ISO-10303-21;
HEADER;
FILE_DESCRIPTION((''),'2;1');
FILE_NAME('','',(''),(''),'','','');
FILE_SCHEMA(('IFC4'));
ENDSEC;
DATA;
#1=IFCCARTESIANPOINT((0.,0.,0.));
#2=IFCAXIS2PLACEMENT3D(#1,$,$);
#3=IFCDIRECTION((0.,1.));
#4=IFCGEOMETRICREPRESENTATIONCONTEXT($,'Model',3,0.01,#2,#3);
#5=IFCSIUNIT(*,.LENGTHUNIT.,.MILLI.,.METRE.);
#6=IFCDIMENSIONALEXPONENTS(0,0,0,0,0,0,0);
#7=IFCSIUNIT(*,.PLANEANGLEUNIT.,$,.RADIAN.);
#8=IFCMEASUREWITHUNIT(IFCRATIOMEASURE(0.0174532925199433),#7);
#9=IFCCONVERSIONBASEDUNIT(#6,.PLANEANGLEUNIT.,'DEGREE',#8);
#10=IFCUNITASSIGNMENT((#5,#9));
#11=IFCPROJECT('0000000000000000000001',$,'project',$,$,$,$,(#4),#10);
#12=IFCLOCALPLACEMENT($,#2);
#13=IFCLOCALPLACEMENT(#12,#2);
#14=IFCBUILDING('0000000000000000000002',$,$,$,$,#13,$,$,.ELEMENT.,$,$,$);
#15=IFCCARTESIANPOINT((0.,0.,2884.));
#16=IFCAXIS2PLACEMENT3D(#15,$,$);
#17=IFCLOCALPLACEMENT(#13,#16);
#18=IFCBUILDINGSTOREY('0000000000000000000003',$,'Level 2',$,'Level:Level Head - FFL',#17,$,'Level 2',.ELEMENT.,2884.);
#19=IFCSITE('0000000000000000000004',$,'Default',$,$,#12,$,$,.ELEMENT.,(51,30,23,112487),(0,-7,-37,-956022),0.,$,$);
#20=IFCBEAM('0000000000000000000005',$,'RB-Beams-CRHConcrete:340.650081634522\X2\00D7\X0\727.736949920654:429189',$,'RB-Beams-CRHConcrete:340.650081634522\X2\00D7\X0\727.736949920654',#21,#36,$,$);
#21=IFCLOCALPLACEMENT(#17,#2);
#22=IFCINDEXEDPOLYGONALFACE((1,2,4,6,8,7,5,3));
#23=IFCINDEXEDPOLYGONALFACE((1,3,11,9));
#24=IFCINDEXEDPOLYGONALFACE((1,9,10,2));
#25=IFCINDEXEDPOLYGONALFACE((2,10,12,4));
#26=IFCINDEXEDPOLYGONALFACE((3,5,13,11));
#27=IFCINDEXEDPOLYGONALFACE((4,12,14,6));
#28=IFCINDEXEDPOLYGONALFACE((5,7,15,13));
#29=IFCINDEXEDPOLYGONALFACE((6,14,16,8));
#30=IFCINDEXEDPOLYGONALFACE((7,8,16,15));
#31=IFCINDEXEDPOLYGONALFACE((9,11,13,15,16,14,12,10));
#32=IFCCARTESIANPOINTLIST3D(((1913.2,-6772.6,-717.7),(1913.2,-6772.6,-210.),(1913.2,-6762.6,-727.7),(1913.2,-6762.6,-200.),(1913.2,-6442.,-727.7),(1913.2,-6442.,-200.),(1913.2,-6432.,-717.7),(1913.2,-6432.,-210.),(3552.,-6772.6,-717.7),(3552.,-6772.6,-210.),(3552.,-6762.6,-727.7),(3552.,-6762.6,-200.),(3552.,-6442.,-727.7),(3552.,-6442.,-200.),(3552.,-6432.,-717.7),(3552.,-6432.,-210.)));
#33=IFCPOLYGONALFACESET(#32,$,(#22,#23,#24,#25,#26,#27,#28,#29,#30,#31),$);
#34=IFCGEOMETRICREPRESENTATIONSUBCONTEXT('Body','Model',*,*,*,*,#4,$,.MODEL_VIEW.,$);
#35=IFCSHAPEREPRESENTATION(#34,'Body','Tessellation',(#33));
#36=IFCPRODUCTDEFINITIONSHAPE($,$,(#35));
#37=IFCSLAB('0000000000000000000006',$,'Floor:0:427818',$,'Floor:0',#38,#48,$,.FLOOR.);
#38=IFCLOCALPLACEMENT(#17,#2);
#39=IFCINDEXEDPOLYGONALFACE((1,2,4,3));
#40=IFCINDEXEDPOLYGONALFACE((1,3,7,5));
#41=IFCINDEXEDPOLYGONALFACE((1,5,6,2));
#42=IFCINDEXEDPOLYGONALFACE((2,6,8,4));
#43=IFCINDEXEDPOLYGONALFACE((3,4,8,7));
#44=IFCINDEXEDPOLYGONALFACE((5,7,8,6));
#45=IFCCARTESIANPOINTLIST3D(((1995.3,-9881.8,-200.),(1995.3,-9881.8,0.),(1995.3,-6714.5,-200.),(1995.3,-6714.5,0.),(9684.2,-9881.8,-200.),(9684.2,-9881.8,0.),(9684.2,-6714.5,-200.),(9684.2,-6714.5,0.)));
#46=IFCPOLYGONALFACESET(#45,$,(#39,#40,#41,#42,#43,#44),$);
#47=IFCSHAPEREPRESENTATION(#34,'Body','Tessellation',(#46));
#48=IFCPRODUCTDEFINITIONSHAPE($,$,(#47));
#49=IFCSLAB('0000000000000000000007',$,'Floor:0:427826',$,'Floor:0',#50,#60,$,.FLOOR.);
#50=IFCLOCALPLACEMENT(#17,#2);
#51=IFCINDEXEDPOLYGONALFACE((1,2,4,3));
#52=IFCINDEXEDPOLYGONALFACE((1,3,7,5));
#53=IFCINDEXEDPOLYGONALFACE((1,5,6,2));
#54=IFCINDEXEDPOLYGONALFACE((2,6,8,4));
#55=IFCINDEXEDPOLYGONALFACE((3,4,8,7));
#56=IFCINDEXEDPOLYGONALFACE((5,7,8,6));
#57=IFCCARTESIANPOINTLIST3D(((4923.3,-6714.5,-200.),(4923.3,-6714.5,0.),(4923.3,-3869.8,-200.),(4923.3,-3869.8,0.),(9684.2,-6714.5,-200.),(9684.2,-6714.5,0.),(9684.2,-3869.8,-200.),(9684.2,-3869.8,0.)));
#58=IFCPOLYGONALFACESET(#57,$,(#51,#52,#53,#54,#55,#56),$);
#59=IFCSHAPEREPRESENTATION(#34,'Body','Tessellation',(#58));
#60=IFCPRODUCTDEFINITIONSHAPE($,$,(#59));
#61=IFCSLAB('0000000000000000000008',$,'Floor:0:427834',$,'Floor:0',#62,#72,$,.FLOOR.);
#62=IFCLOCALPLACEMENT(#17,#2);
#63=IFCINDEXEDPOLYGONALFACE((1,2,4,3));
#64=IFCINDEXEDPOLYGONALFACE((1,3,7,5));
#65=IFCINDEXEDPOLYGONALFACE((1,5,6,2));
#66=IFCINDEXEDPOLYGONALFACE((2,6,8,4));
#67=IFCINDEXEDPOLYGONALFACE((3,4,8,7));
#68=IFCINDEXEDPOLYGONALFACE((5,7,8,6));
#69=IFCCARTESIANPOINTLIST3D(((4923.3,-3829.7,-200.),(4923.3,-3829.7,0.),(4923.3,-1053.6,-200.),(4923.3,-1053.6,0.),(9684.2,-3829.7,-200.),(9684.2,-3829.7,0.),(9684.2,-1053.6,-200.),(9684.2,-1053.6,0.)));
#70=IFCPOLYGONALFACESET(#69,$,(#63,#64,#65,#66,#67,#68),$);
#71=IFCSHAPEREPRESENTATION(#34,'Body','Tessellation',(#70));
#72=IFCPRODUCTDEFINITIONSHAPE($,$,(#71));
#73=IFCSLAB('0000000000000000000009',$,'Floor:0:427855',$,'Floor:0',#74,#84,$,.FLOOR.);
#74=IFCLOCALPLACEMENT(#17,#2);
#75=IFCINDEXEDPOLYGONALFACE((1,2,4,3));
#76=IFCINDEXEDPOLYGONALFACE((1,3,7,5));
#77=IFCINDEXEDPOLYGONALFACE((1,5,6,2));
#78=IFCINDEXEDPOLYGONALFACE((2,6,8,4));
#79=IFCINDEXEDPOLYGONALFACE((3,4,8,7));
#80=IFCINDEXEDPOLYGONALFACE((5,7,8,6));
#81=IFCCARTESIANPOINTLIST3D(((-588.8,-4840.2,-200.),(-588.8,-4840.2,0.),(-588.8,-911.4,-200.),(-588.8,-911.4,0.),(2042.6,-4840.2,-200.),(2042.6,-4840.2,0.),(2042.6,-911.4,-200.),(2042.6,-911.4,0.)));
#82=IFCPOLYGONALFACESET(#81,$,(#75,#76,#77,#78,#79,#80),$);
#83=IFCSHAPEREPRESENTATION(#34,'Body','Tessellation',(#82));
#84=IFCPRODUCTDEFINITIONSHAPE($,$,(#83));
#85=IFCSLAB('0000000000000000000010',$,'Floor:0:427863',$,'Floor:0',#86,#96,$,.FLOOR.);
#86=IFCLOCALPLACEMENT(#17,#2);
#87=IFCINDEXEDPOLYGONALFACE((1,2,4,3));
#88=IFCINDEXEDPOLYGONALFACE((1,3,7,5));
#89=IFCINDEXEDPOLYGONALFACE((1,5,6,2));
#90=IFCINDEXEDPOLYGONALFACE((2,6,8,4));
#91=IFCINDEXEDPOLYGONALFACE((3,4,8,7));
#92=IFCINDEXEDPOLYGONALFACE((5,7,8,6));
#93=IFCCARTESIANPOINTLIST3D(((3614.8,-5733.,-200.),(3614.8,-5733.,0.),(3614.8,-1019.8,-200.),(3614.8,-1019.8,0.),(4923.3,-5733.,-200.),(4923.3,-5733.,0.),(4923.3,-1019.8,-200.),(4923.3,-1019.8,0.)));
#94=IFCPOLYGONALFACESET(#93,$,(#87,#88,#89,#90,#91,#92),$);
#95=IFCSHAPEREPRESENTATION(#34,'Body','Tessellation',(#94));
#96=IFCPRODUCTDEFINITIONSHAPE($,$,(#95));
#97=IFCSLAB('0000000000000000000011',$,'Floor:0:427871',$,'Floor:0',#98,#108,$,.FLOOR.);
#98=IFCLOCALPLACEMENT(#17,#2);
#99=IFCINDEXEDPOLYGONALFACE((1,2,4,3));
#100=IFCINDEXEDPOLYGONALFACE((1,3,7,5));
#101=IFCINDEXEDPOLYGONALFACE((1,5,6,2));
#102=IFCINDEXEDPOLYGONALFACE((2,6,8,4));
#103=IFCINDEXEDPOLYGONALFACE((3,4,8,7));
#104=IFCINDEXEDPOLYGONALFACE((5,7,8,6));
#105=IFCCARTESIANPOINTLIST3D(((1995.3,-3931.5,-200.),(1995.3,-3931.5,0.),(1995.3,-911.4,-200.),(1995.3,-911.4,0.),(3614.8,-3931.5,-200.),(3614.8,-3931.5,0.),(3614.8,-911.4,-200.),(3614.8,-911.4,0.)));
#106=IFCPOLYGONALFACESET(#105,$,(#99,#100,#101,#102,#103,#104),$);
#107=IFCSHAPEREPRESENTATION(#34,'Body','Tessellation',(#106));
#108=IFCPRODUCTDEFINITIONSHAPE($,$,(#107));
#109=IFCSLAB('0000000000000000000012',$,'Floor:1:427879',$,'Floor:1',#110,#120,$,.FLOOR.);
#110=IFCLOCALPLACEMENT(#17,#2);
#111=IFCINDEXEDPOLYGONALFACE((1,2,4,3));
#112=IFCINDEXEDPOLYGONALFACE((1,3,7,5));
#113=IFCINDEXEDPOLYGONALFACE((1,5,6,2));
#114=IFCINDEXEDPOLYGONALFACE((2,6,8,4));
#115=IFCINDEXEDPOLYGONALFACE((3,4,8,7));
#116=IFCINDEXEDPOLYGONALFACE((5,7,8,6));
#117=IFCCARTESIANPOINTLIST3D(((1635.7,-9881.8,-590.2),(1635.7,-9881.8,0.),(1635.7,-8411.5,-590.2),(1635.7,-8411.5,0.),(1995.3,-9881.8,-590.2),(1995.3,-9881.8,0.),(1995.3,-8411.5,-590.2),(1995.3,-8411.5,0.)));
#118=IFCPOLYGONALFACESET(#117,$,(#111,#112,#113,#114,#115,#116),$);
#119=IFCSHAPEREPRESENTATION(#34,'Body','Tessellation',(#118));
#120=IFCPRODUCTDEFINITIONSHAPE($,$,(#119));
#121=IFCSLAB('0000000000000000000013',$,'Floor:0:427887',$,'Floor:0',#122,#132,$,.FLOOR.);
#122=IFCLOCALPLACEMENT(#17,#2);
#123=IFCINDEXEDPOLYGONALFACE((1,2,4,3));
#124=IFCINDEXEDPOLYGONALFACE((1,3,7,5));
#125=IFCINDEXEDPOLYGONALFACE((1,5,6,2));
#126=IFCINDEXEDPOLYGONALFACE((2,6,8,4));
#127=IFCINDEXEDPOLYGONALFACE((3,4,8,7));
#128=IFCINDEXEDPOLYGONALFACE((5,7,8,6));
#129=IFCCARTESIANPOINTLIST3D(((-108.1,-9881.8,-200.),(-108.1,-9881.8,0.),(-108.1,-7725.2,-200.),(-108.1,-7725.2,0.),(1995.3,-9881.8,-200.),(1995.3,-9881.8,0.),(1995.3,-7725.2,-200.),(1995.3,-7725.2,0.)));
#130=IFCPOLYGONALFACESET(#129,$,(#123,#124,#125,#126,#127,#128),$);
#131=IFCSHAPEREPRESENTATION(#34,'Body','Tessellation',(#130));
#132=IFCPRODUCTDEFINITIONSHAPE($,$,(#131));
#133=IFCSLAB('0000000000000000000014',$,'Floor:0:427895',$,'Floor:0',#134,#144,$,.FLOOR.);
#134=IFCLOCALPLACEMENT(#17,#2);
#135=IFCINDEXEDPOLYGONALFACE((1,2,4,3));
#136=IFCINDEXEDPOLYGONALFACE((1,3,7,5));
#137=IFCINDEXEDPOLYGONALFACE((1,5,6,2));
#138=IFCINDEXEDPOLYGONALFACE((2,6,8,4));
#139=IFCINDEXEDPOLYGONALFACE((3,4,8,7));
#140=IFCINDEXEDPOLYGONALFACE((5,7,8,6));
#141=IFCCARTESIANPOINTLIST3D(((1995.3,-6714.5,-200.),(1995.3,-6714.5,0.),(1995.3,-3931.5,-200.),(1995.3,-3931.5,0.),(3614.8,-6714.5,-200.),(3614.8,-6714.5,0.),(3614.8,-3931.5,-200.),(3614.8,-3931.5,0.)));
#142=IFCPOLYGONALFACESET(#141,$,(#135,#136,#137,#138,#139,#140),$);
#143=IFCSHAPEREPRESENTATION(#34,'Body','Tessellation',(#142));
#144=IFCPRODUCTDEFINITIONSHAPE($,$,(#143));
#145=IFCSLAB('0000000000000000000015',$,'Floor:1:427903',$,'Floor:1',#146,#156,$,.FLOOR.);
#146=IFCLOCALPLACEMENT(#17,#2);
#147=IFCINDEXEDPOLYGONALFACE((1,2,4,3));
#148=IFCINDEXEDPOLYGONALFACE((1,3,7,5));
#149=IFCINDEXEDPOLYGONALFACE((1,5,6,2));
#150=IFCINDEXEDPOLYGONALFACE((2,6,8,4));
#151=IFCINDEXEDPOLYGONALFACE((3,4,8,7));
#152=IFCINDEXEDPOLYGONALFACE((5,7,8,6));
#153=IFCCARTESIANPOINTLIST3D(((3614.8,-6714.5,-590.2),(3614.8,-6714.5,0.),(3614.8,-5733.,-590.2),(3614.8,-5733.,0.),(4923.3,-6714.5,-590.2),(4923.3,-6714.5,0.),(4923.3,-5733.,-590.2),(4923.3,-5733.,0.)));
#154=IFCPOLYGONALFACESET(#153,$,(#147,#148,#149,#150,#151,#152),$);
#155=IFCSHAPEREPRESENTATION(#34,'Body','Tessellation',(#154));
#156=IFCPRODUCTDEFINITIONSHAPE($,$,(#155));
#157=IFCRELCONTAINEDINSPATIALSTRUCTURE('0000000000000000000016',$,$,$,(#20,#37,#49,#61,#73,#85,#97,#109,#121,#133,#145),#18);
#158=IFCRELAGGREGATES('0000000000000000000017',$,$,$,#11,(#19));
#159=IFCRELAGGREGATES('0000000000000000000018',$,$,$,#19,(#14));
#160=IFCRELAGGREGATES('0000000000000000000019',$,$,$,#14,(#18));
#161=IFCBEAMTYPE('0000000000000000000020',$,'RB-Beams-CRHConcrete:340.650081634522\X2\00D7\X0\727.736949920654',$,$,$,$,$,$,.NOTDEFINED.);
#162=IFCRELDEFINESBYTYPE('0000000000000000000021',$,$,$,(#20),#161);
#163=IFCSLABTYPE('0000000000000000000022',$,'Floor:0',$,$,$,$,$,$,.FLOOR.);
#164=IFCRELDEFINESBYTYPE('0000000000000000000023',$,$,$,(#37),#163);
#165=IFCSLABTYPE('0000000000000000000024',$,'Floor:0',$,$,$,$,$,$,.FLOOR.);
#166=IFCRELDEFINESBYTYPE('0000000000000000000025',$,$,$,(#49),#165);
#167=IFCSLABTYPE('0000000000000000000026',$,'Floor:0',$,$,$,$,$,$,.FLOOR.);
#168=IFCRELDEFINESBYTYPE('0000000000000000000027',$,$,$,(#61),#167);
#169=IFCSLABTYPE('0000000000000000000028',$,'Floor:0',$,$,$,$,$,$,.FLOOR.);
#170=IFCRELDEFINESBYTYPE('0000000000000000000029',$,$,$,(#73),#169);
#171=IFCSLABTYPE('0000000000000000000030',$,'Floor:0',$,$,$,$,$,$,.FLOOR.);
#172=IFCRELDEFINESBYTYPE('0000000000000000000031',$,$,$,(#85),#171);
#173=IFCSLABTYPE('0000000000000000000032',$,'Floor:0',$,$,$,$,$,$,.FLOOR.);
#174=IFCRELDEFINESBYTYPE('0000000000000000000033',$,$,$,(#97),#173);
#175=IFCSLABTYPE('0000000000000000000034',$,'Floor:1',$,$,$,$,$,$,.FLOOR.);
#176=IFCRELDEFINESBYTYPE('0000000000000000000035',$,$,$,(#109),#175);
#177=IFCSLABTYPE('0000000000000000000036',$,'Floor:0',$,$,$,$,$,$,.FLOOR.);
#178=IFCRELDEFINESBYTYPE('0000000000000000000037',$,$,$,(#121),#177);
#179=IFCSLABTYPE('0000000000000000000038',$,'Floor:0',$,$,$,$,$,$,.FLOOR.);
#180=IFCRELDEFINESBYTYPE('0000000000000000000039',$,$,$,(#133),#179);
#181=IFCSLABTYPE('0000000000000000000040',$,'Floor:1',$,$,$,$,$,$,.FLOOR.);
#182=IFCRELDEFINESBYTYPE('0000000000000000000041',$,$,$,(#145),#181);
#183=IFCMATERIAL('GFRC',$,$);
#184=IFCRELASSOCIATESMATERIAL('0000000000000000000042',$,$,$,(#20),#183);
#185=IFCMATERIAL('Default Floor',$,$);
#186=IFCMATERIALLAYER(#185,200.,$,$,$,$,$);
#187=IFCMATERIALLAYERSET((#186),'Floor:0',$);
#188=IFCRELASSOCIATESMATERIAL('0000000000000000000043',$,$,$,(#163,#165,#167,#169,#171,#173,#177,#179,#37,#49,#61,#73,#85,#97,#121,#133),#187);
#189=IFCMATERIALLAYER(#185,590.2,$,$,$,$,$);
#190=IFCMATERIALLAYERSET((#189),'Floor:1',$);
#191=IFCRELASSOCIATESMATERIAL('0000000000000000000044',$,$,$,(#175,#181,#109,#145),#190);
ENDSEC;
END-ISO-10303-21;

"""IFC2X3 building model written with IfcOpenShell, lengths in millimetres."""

from ifc_helpers import new_model, entity, si_unit, converted_unit, direction, frame, frame_2d, origin, origin_2d_with_axis, place, context, subcontext, project, spatial, polyline, rectangle, outline, extrude, material, layer, layer_set, layer_usage, type_object, element, save


model = new_model("IFC2X3")

# Units and contexts
model_context = context("Model", 3, precision=0.01, world=origin(), true_north=direction((0.0, 1.0)))
body_context = subcontext(model_context, "Body", "Model", "MODEL_VIEW")
ifc_project = project(units=[si_unit("LENGTHUNIT", "METRE", prefix="MILLI"), converted_unit("PLANEANGLEUNIT", "DEGREE", entity("IfcRatioMeasure", 0.0174532925199433), si_unit("PLANEANGLEUNIT", "RADIAN"), dimensions=[0, 0, 0, 0, 0, 0, 0])], contexts=[model_context])

# Site, building, storey
site_placement = place(None, origin())
site = spatial("IfcSite", under=ifc_project, at=site_placement, Name="Default", CompositionType="ELEMENT", RefLatitude=(51, 30, 23, 112487), RefLongitude=(0, -7, -37, -956022), RefElevation=0.0)
building_placement = place(site_placement, origin())
building = spatial("IfcBuilding", under=site, at=building_placement, CompositionType="ELEMENT")
storey_placement = place(building_placement, frame((0.0, 0.0, 2884.0)))
storey = spatial("IfcBuildingStorey", under=building, at=storey_placement, Name="Level 2", ObjectType="Level:Level Head - FFL", LongName="Level 2", CompositionType="ELEMENT", Elevation=2884.0)

# Beam
ifc_material_1 = material(Name="GFRC")
beam_type_1 = type_object("IfcBeamType", Name="RB-Beams-CRHConcrete:340.650081634522×727.736949920654", PredefinedType="NOTDEFINED")
beam_1_placement = place(storey_placement, frame((1913.2, -6602.3, -200.0)))
element("IfcBeam", 1, at=beam_1_placement, inside=storey, type_object=beam_type_1, material=ifc_material_1, Name="RB-Beams-CRHConcrete:340.650081634522×727.736949920654:429189", ObjectType="RB-Beams-CRHConcrete:340.650081634522×727.736949920654", context=body_context, shape_type="SweptSolid", body=[
    extrude(outline(polyline([(-253.9, -170.3), (253.9, -170.3), (263.9, -160.3), (263.9, 160.3), (253.9, 170.3), (-253.9, 170.3), (-263.9, 160.3), (-263.9, -160.3), (-253.9, -170.3)])), frame((0.0, 0.0, -263.9), z_axis=(1.0, 0.0, 0.0), x_axis=(0.0, 0.0, -1.0)), (0.0, 0.0, 1.0), 1638.8),
])

# Slabs
ifc_material_2 = material(Name="Default Floor")
ifc_layer_1 = layer(ifc_material_2, 200.0)
ifc_layer_set_1 = layer_set([ifc_layer_1], Name="Floor:0")
ifc_layer_usage_1 = layer_usage(ifc_layer_set_1, "AXIS3", "POSITIVE", 0.0)
slab_type_1 = type_object("IfcSlabType", Name="Floor:0", PredefinedType="FLOOR", material=ifc_layer_set_1)
slab_1_placement = place(storey_placement, origin())
element("IfcSlab", 2, at=slab_1_placement, inside=storey, type_object=slab_type_1, material=ifc_layer_usage_1, Name="Floor:0:427818", ObjectType="Floor:0", PredefinedType="FLOOR", context=body_context, shape_type="SweptSolid", body=[
    extrude(rectangle(XDim=3167.4, YDim=7688.9, at=frame_2d((0.0, 0.0), x_axis=(1.0, 0.0))), frame((5839.8, -8298.2, 0.0), z_axis=(0.0, 0.0, -1.0), x_axis=(0.0, 1.0, 0.0)), (0.0, 0.0, 1.0), 200.0),
])
ifc_layer_usage_2 = layer_usage(ifc_layer_set_1, "AXIS3", "POSITIVE", 0.0)
slab_type_2 = type_object("IfcSlabType", Name="Floor:0", PredefinedType="FLOOR", material=ifc_layer_set_1)
slab_2_placement = place(storey_placement, origin())
element("IfcSlab", 3, at=slab_2_placement, inside=storey, type_object=slab_type_2, material=ifc_layer_usage_2, Name="Floor:0:427826", ObjectType="Floor:0", PredefinedType="FLOOR", context=body_context, shape_type="SweptSolid", body=[
    extrude(rectangle(XDim=2844.7, YDim=4761.0, at=frame_2d((0.0, 0.0), x_axis=(1.0, 0.0))), frame((7303.8, -5292.1, 0.0), z_axis=(0.0, 0.0, -1.0), x_axis=(0.0, 1.0, 0.0)), (0.0, 0.0, 1.0), 200.0),
])
ifc_layer_usage_3 = layer_usage(ifc_layer_set_1, "AXIS3", "POSITIVE", 0.0)
slab_type_3 = type_object("IfcSlabType", Name="Floor:0", PredefinedType="FLOOR", material=ifc_layer_set_1)
slab_3_placement = place(storey_placement, origin())
element("IfcSlab", 4, at=slab_3_placement, inside=storey, type_object=slab_type_3, material=ifc_layer_usage_3, Name="Floor:0:427834", ObjectType="Floor:0", PredefinedType="FLOOR", context=body_context, shape_type="SweptSolid", body=[
    extrude(rectangle(XDim=2776.1, YDim=4761.0, at=frame_2d((0.0, 0.0), x_axis=(1.0, 0.0))), frame((7303.8, -2441.6, 0.0), z_axis=(0.0, 0.0, -1.0), x_axis=(0.0, 1.0, 0.0)), (0.0, 0.0, 1.0), 200.0),
])
ifc_layer_2 = layer(ifc_material_2, 590.2)
ifc_layer_set_2 = layer_set([ifc_layer_2], Name="Floor:1")
ifc_layer_usage_4 = layer_usage(ifc_layer_set_1, "AXIS3", "POSITIVE", 0.0)
slab_type_4 = type_object("IfcSlabType", Name="Floor:0", PredefinedType="FLOOR", material=ifc_layer_set_1)
slab_4_placement = place(storey_placement, origin())
element("IfcSlab", 5, at=slab_4_placement, inside=storey, type_object=slab_type_4, material=ifc_layer_usage_4, Name="Floor:0:427855", ObjectType="Floor:0", PredefinedType="FLOOR", context=body_context, shape_type="SweptSolid", body=[
    extrude(rectangle(XDim=3928.8, YDim=2631.4, at=frame_2d((0.0, 0.0), x_axis=(1.0, 0.0))), frame((726.9, -2875.8, 0.0), z_axis=(0.0, 0.0, -1.0), x_axis=(0.0, 1.0, 0.0)), (0.0, 0.0, 1.0), 200.0),
])
ifc_layer_usage_5 = layer_usage(ifc_layer_set_1, "AXIS3", "POSITIVE", 0.0)
slab_type_5 = type_object("IfcSlabType", Name="Floor:0", PredefinedType="FLOOR", material=ifc_layer_set_1)
slab_5_placement = place(storey_placement, origin())
element("IfcSlab", 6, at=slab_5_placement, inside=storey, type_object=slab_type_5, material=ifc_layer_usage_5, Name="Floor:0:427863", ObjectType="Floor:0", PredefinedType="FLOOR", context=body_context, shape_type="SweptSolid", body=[
    extrude(rectangle(XDim=4713.3, YDim=1308.5, at=origin_2d_with_axis()), frame((4269.0, -3376.4, 0.0), z_axis=(0.0, 0.0, -1.0), x_axis=(0.0, 1.0, 0.0)), (0.0, 0.0, 1.0), 200.0),
])
ifc_layer_usage_6 = layer_usage(ifc_layer_set_1, "AXIS3", "POSITIVE", 0.0)
slab_type_6 = type_object("IfcSlabType", Name="Floor:0", PredefinedType="FLOOR", material=ifc_layer_set_1)
slab_6_placement = place(storey_placement, origin())
element("IfcSlab", 7, at=slab_6_placement, inside=storey, type_object=slab_type_6, material=ifc_layer_usage_6, Name="Floor:0:427871", ObjectType="Floor:0", PredefinedType="FLOOR", context=body_context, shape_type="SweptSolid", body=[
    extrude(rectangle(XDim=3020.1, YDim=1619.5, at=frame_2d((0.0, 0.0), x_axis=(1.0, 0.0))), frame((2805.1, -2421.5, 0.0), z_axis=(0.0, 0.0, -1.0), x_axis=(0.0, 1.0, 0.0)), (0.0, 0.0, 1.0), 200.0),
])
ifc_layer_usage_7 = layer_usage(ifc_layer_set_2, "AXIS3", "POSITIVE", 0.0)
slab_type_7 = type_object("IfcSlabType", Name="Floor:1", PredefinedType="FLOOR", material=ifc_layer_set_2)
slab_7_placement = place(storey_placement, origin())
element("IfcSlab", 8, at=slab_7_placement, inside=storey, type_object=slab_type_7, material=ifc_layer_usage_7, Name="Floor:1:427879", ObjectType="Floor:1", PredefinedType="FLOOR", context=body_context, shape_type="SweptSolid", body=[
    extrude(rectangle(XDim=1470.3, YDim=359.7, at=frame_2d((0.0, 0.0), x_axis=(1.0, 0.0))), frame((1815.5, -9146.7, 0.0), z_axis=(0.0, 0.0, -1.0), x_axis=(0.0, 1.0, 0.0)), (0.0, 0.0, 1.0), 590.2),
])
ifc_layer_usage_8 = layer_usage(ifc_layer_set_1, "AXIS3", "POSITIVE", 0.0)
slab_type_8 = type_object("IfcSlabType", Name="Floor:0", PredefinedType="FLOOR", material=ifc_layer_set_1)
slab_8_placement = place(storey_placement, origin())
element("IfcSlab", 9, at=slab_8_placement, inside=storey, type_object=slab_type_8, material=ifc_layer_usage_8, Name="Floor:0:427887", ObjectType="Floor:0", PredefinedType="FLOOR", context=body_context, shape_type="SweptSolid", body=[
    extrude(rectangle(XDim=2156.7, YDim=2103.4, at=origin_2d_with_axis()), frame((943.6, -8803.5, 0.0), z_axis=(0.0, 0.0, -1.0), x_axis=(0.0, 1.0, 0.0)), (0.0, 0.0, 1.0), 200.0),
])
ifc_layer_usage_9 = layer_usage(ifc_layer_set_1, "AXIS3", "POSITIVE", 0.0)
slab_type_9 = type_object("IfcSlabType", Name="Floor:0", PredefinedType="FLOOR", material=ifc_layer_set_1)
slab_9_placement = place(storey_placement, origin())
element("IfcSlab", 10, at=slab_9_placement, inside=storey, type_object=slab_type_9, material=ifc_layer_usage_9, Name="Floor:0:427895", ObjectType="Floor:0", PredefinedType="FLOOR", context=body_context, shape_type="SweptSolid", body=[
    extrude(rectangle(XDim=2783.0, YDim=1619.5, at=frame_2d((0.0, 0.0), x_axis=(1.0, 0.0))), frame((2805.1, -5323.0, 0.0), z_axis=(0.0, 0.0, -1.0), x_axis=(0.0, 1.0, 0.0)), (0.0, 0.0, 1.0), 200.0),
])
ifc_layer_usage_10 = layer_usage(ifc_layer_set_2, "AXIS3", "POSITIVE", 0.0)
slab_type_10 = type_object("IfcSlabType", Name="Floor:1", PredefinedType="FLOOR", material=ifc_layer_set_2)
slab_10_placement = place(storey_placement, origin())
element("IfcSlab", 11, at=slab_10_placement, inside=storey, type_object=slab_type_10, material=ifc_layer_usage_10, Name="Floor:1:427903", ObjectType="Floor:1", PredefinedType="FLOOR", context=body_context, shape_type="SweptSolid", body=[
    extrude(rectangle(XDim=981.5, YDim=1308.5, at=origin_2d_with_axis()), frame((4269.0, -6223.7, 0.0), z_axis=(0.0, 0.0, -1.0), x_axis=(0.0, 1.0, 0.0)), (0.0, 0.0, 1.0), 590.2),
])

save(model, "model.ifc")
